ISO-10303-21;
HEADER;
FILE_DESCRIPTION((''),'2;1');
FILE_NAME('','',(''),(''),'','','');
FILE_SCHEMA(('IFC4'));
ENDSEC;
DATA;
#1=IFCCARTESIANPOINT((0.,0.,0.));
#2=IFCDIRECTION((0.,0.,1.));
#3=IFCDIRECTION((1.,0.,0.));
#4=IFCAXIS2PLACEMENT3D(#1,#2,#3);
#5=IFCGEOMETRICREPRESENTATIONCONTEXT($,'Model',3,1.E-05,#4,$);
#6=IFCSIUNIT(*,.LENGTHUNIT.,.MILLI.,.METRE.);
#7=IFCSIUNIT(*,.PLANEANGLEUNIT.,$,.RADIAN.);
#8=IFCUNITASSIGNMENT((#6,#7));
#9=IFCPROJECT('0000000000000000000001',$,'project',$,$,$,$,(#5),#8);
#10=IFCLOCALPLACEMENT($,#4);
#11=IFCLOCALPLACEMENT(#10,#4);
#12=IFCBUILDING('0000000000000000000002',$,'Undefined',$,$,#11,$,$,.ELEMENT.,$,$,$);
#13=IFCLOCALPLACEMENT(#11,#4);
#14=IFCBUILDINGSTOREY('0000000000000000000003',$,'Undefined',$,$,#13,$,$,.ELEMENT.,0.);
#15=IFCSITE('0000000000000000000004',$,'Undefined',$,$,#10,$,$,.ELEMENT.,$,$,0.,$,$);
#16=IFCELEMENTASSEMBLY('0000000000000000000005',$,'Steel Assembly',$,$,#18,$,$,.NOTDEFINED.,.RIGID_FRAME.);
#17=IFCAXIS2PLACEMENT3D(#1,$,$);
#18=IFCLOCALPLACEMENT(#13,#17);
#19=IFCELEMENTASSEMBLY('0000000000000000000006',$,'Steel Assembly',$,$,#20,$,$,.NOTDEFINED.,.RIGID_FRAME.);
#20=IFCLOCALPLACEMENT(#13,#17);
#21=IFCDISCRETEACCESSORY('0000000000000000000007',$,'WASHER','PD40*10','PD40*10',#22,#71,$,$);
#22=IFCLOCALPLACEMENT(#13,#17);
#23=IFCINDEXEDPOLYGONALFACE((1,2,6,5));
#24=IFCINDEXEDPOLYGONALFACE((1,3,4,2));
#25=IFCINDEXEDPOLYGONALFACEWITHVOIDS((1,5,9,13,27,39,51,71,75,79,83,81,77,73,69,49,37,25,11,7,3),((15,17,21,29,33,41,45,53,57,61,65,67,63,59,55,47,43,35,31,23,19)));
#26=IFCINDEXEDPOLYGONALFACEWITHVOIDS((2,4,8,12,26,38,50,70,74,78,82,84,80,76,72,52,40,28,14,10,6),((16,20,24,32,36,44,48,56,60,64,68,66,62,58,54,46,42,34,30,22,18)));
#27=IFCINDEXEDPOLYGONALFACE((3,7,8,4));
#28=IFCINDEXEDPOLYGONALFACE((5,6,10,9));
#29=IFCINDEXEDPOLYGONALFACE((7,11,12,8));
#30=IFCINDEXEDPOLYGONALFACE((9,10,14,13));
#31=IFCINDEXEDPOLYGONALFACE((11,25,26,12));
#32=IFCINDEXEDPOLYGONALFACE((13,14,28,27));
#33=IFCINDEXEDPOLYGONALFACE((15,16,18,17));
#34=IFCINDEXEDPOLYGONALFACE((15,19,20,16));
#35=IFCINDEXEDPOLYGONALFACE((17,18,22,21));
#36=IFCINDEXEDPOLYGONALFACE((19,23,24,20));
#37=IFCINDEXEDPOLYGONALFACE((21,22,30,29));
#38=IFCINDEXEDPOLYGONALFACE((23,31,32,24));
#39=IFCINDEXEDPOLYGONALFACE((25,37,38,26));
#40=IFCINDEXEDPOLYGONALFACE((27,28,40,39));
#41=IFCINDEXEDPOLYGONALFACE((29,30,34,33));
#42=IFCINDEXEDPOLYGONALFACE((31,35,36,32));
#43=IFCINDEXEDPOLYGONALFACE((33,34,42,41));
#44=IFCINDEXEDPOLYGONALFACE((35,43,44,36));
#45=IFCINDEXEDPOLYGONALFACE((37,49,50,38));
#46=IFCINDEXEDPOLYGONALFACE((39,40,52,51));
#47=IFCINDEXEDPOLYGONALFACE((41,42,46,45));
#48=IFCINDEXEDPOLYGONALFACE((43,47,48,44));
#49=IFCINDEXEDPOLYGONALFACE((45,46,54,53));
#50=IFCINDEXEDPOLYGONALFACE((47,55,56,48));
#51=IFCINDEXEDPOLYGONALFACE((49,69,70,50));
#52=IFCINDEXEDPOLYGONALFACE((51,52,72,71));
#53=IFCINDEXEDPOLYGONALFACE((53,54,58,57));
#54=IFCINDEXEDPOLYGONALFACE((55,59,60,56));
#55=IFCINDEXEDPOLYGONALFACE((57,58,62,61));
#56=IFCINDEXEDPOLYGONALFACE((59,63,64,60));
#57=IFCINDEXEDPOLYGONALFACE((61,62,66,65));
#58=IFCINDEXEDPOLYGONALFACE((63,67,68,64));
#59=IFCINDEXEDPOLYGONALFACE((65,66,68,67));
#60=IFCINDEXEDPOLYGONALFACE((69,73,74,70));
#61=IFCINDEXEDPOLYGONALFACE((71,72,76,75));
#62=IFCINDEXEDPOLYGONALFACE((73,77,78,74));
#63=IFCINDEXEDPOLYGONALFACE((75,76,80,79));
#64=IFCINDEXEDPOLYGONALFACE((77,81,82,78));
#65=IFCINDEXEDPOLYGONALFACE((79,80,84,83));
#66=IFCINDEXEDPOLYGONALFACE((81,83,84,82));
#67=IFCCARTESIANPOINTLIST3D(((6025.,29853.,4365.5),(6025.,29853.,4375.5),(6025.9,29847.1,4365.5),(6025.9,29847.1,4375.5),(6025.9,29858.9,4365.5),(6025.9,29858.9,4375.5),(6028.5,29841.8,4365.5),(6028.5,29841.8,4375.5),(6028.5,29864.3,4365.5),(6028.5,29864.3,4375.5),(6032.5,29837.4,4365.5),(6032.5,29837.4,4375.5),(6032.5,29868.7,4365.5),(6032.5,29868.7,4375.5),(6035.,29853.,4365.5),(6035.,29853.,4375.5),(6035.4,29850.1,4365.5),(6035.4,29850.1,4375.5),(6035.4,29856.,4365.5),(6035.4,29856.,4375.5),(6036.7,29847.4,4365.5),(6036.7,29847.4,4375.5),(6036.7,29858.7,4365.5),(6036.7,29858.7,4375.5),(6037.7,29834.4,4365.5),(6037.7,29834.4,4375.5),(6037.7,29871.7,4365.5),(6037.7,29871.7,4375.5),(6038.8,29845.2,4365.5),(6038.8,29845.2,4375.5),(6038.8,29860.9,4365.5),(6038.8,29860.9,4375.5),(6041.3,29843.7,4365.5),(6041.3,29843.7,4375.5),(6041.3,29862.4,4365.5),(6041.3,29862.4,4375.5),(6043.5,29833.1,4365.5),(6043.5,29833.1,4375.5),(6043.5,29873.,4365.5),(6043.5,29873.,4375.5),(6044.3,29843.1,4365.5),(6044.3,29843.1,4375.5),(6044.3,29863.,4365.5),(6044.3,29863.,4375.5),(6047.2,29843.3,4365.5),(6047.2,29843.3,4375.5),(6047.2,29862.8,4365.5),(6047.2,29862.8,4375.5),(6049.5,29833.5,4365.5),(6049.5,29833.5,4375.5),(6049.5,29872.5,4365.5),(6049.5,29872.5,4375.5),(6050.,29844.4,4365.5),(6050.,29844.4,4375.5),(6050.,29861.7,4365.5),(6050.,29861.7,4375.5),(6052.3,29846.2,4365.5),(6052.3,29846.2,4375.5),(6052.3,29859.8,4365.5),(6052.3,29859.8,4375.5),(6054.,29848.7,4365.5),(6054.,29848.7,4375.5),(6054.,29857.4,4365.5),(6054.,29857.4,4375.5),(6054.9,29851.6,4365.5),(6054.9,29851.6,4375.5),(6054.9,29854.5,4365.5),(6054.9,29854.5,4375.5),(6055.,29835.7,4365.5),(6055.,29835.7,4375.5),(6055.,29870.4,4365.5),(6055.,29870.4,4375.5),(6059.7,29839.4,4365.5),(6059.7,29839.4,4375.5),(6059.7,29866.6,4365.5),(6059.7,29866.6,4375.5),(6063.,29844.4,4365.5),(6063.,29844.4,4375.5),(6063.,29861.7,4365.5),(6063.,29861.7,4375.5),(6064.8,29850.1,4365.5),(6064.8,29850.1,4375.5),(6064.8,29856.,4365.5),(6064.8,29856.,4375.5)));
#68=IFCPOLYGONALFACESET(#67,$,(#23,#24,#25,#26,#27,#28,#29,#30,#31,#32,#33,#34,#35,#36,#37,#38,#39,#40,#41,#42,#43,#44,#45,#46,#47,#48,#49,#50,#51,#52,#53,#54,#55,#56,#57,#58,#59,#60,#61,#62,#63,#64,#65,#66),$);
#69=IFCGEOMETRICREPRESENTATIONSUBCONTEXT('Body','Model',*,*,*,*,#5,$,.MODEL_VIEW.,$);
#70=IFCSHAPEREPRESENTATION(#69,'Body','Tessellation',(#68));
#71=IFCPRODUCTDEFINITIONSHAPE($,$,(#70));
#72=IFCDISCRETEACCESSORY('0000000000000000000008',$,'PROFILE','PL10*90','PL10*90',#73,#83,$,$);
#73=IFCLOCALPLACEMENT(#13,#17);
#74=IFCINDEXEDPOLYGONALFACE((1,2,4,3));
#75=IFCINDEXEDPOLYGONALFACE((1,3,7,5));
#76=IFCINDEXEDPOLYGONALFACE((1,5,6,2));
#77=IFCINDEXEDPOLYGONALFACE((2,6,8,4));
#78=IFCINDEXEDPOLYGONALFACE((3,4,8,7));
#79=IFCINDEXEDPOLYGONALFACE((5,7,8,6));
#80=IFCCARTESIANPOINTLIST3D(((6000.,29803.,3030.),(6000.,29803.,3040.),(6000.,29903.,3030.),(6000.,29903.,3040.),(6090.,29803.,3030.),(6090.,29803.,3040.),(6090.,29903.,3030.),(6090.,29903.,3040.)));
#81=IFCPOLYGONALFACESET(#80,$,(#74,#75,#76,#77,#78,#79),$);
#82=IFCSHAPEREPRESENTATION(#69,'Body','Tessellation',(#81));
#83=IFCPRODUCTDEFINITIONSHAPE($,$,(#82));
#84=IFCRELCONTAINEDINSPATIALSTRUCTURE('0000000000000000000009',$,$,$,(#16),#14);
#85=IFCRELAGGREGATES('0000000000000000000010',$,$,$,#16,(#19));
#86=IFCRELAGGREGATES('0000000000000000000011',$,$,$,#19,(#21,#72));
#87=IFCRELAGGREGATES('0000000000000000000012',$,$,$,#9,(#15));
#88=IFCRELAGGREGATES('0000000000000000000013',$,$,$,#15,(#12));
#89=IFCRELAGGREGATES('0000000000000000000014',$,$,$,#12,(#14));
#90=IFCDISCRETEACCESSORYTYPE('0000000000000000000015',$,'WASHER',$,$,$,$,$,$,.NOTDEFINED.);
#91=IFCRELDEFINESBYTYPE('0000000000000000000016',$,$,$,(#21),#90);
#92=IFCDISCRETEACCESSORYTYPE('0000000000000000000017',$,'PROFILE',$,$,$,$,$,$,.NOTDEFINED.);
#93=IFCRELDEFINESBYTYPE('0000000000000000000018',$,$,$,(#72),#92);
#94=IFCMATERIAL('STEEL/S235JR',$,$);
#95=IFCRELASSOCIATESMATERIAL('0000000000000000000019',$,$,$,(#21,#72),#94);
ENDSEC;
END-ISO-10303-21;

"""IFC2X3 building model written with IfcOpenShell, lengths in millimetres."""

from ifc_helpers import new_model, si_unit, frame, origin_with_axes, origin_2d_with_axis, place, context, subcontext, project, spatial, polyline, hollow_circle, outline, extrude, material, type_object, element, aggregate, save


model = new_model("IFC2X3")

# Units and contexts
model_context = context("Model", 3, precision=1e-05, world=origin_with_axes())
body_context = subcontext(model_context, "Body", "Model", "MODEL_VIEW")
ifc_project = project(units=[si_unit("LENGTHUNIT", "METRE", prefix="MILLI"), si_unit("PLANEANGLEUNIT", "RADIAN")], contexts=[model_context])

# Site, building, storey
site_placement = place(None, origin_with_axes())
site = spatial("IfcSite", under=ifc_project, at=site_placement, Name="Undefined", CompositionType="ELEMENT", RefElevation=0.0)
building_placement = place(site_placement, origin_with_axes())
building = spatial("IfcBuilding", under=site, at=building_placement, Name="Undefined", CompositionType="ELEMENT")
storey_placement = place(building_placement, origin_with_axes())
storey = spatial("IfcBuildingStorey", under=building, at=storey_placement, Name="Undefined", CompositionType="ELEMENT", Elevation=0.0)

# Element assemblies
assembly_1_placement = place(storey_placement, origin_with_axes())
assembly_1 = element("IfcElementAssembly", 1, at=assembly_1_placement, inside=storey, Name="Steel Assembly", AssemblyPlace="NOTDEFINED", PredefinedType="RIGID_FRAME")
assembly_2_placement = place(assembly_1_placement, origin_with_axes())
assembly_2 = element("IfcElementAssembly", 2, at=assembly_2_placement, Name="Steel Assembly", AssemblyPlace="NOTDEFINED", PredefinedType="RIGID_FRAME")
aggregate(assembly_1, [assembly_2])

# Shared definitions
ifc_material_1 = material(Name="STEEL/S235JR")

# Discrete accessories
discrete_accessory_type_1 = type_object("IfcDiscreteAccessoryType", Name="WASHER")
discrete_accessory_1_placement = place(assembly_2_placement, frame((6045.0, 29853.0, 4375.5), z_axis=(0.0, -1.0, 0.0), x_axis=(0.0, 0.0, -1.0)))
discrete_accessory_1 = element("IfcDiscreteAccessory", 3, at=discrete_accessory_1_placement, type_object=discrete_accessory_type_1, material=ifc_material_1, Name="WASHER", Description="PD40*10", ObjectType="PD40*10", context=body_context, shape_type="SweptSolid", body=[
    extrude(hollow_circle(Radius=20.0, WallThickness=10.0, at=origin_2d_with_axis()), frame((10.0, 0.0, 0.0), z_axis=(-1.0, 0.0, 0.0), x_axis=(0.0, -1.0, 0.0)), (0.0, 0.0, 1.0), 10.0),
])
discrete_accessory_type_2 = type_object("IfcDiscreteAccessoryType", Name="PROFILE")
discrete_accessory_2_placement = place(assembly_2_placement, frame((6045.0, 29903.0, 3035.0), z_axis=(0.0, 0.0, 1.0), x_axis=(0.0, -1.0, 0.0)))
discrete_accessory_2 = element("IfcDiscreteAccessory", 4, at=discrete_accessory_2_placement, type_object=discrete_accessory_type_2, material=ifc_material_1, Name="PROFILE", Description="PL10*90", ObjectType="PL10*90", context=body_context, shape_type="SweptSolid", body=[
    extrude(outline(polyline([(100.0, -45.0), (0.0, -45.0), (0.0, 45.0), (100.0, 45.0), (100.0, -45.0)])), frame((0.0, 0.0, -5.0), z_axis=(0.0, 0.0, 1.0), x_axis=(1.0, 0.0, 0.0)), (0.0, 0.0, 1.0), 10.0),
])
aggregate(assembly_2, [discrete_accessory_1, discrete_accessory_2])

save(model, "model.ifc")
